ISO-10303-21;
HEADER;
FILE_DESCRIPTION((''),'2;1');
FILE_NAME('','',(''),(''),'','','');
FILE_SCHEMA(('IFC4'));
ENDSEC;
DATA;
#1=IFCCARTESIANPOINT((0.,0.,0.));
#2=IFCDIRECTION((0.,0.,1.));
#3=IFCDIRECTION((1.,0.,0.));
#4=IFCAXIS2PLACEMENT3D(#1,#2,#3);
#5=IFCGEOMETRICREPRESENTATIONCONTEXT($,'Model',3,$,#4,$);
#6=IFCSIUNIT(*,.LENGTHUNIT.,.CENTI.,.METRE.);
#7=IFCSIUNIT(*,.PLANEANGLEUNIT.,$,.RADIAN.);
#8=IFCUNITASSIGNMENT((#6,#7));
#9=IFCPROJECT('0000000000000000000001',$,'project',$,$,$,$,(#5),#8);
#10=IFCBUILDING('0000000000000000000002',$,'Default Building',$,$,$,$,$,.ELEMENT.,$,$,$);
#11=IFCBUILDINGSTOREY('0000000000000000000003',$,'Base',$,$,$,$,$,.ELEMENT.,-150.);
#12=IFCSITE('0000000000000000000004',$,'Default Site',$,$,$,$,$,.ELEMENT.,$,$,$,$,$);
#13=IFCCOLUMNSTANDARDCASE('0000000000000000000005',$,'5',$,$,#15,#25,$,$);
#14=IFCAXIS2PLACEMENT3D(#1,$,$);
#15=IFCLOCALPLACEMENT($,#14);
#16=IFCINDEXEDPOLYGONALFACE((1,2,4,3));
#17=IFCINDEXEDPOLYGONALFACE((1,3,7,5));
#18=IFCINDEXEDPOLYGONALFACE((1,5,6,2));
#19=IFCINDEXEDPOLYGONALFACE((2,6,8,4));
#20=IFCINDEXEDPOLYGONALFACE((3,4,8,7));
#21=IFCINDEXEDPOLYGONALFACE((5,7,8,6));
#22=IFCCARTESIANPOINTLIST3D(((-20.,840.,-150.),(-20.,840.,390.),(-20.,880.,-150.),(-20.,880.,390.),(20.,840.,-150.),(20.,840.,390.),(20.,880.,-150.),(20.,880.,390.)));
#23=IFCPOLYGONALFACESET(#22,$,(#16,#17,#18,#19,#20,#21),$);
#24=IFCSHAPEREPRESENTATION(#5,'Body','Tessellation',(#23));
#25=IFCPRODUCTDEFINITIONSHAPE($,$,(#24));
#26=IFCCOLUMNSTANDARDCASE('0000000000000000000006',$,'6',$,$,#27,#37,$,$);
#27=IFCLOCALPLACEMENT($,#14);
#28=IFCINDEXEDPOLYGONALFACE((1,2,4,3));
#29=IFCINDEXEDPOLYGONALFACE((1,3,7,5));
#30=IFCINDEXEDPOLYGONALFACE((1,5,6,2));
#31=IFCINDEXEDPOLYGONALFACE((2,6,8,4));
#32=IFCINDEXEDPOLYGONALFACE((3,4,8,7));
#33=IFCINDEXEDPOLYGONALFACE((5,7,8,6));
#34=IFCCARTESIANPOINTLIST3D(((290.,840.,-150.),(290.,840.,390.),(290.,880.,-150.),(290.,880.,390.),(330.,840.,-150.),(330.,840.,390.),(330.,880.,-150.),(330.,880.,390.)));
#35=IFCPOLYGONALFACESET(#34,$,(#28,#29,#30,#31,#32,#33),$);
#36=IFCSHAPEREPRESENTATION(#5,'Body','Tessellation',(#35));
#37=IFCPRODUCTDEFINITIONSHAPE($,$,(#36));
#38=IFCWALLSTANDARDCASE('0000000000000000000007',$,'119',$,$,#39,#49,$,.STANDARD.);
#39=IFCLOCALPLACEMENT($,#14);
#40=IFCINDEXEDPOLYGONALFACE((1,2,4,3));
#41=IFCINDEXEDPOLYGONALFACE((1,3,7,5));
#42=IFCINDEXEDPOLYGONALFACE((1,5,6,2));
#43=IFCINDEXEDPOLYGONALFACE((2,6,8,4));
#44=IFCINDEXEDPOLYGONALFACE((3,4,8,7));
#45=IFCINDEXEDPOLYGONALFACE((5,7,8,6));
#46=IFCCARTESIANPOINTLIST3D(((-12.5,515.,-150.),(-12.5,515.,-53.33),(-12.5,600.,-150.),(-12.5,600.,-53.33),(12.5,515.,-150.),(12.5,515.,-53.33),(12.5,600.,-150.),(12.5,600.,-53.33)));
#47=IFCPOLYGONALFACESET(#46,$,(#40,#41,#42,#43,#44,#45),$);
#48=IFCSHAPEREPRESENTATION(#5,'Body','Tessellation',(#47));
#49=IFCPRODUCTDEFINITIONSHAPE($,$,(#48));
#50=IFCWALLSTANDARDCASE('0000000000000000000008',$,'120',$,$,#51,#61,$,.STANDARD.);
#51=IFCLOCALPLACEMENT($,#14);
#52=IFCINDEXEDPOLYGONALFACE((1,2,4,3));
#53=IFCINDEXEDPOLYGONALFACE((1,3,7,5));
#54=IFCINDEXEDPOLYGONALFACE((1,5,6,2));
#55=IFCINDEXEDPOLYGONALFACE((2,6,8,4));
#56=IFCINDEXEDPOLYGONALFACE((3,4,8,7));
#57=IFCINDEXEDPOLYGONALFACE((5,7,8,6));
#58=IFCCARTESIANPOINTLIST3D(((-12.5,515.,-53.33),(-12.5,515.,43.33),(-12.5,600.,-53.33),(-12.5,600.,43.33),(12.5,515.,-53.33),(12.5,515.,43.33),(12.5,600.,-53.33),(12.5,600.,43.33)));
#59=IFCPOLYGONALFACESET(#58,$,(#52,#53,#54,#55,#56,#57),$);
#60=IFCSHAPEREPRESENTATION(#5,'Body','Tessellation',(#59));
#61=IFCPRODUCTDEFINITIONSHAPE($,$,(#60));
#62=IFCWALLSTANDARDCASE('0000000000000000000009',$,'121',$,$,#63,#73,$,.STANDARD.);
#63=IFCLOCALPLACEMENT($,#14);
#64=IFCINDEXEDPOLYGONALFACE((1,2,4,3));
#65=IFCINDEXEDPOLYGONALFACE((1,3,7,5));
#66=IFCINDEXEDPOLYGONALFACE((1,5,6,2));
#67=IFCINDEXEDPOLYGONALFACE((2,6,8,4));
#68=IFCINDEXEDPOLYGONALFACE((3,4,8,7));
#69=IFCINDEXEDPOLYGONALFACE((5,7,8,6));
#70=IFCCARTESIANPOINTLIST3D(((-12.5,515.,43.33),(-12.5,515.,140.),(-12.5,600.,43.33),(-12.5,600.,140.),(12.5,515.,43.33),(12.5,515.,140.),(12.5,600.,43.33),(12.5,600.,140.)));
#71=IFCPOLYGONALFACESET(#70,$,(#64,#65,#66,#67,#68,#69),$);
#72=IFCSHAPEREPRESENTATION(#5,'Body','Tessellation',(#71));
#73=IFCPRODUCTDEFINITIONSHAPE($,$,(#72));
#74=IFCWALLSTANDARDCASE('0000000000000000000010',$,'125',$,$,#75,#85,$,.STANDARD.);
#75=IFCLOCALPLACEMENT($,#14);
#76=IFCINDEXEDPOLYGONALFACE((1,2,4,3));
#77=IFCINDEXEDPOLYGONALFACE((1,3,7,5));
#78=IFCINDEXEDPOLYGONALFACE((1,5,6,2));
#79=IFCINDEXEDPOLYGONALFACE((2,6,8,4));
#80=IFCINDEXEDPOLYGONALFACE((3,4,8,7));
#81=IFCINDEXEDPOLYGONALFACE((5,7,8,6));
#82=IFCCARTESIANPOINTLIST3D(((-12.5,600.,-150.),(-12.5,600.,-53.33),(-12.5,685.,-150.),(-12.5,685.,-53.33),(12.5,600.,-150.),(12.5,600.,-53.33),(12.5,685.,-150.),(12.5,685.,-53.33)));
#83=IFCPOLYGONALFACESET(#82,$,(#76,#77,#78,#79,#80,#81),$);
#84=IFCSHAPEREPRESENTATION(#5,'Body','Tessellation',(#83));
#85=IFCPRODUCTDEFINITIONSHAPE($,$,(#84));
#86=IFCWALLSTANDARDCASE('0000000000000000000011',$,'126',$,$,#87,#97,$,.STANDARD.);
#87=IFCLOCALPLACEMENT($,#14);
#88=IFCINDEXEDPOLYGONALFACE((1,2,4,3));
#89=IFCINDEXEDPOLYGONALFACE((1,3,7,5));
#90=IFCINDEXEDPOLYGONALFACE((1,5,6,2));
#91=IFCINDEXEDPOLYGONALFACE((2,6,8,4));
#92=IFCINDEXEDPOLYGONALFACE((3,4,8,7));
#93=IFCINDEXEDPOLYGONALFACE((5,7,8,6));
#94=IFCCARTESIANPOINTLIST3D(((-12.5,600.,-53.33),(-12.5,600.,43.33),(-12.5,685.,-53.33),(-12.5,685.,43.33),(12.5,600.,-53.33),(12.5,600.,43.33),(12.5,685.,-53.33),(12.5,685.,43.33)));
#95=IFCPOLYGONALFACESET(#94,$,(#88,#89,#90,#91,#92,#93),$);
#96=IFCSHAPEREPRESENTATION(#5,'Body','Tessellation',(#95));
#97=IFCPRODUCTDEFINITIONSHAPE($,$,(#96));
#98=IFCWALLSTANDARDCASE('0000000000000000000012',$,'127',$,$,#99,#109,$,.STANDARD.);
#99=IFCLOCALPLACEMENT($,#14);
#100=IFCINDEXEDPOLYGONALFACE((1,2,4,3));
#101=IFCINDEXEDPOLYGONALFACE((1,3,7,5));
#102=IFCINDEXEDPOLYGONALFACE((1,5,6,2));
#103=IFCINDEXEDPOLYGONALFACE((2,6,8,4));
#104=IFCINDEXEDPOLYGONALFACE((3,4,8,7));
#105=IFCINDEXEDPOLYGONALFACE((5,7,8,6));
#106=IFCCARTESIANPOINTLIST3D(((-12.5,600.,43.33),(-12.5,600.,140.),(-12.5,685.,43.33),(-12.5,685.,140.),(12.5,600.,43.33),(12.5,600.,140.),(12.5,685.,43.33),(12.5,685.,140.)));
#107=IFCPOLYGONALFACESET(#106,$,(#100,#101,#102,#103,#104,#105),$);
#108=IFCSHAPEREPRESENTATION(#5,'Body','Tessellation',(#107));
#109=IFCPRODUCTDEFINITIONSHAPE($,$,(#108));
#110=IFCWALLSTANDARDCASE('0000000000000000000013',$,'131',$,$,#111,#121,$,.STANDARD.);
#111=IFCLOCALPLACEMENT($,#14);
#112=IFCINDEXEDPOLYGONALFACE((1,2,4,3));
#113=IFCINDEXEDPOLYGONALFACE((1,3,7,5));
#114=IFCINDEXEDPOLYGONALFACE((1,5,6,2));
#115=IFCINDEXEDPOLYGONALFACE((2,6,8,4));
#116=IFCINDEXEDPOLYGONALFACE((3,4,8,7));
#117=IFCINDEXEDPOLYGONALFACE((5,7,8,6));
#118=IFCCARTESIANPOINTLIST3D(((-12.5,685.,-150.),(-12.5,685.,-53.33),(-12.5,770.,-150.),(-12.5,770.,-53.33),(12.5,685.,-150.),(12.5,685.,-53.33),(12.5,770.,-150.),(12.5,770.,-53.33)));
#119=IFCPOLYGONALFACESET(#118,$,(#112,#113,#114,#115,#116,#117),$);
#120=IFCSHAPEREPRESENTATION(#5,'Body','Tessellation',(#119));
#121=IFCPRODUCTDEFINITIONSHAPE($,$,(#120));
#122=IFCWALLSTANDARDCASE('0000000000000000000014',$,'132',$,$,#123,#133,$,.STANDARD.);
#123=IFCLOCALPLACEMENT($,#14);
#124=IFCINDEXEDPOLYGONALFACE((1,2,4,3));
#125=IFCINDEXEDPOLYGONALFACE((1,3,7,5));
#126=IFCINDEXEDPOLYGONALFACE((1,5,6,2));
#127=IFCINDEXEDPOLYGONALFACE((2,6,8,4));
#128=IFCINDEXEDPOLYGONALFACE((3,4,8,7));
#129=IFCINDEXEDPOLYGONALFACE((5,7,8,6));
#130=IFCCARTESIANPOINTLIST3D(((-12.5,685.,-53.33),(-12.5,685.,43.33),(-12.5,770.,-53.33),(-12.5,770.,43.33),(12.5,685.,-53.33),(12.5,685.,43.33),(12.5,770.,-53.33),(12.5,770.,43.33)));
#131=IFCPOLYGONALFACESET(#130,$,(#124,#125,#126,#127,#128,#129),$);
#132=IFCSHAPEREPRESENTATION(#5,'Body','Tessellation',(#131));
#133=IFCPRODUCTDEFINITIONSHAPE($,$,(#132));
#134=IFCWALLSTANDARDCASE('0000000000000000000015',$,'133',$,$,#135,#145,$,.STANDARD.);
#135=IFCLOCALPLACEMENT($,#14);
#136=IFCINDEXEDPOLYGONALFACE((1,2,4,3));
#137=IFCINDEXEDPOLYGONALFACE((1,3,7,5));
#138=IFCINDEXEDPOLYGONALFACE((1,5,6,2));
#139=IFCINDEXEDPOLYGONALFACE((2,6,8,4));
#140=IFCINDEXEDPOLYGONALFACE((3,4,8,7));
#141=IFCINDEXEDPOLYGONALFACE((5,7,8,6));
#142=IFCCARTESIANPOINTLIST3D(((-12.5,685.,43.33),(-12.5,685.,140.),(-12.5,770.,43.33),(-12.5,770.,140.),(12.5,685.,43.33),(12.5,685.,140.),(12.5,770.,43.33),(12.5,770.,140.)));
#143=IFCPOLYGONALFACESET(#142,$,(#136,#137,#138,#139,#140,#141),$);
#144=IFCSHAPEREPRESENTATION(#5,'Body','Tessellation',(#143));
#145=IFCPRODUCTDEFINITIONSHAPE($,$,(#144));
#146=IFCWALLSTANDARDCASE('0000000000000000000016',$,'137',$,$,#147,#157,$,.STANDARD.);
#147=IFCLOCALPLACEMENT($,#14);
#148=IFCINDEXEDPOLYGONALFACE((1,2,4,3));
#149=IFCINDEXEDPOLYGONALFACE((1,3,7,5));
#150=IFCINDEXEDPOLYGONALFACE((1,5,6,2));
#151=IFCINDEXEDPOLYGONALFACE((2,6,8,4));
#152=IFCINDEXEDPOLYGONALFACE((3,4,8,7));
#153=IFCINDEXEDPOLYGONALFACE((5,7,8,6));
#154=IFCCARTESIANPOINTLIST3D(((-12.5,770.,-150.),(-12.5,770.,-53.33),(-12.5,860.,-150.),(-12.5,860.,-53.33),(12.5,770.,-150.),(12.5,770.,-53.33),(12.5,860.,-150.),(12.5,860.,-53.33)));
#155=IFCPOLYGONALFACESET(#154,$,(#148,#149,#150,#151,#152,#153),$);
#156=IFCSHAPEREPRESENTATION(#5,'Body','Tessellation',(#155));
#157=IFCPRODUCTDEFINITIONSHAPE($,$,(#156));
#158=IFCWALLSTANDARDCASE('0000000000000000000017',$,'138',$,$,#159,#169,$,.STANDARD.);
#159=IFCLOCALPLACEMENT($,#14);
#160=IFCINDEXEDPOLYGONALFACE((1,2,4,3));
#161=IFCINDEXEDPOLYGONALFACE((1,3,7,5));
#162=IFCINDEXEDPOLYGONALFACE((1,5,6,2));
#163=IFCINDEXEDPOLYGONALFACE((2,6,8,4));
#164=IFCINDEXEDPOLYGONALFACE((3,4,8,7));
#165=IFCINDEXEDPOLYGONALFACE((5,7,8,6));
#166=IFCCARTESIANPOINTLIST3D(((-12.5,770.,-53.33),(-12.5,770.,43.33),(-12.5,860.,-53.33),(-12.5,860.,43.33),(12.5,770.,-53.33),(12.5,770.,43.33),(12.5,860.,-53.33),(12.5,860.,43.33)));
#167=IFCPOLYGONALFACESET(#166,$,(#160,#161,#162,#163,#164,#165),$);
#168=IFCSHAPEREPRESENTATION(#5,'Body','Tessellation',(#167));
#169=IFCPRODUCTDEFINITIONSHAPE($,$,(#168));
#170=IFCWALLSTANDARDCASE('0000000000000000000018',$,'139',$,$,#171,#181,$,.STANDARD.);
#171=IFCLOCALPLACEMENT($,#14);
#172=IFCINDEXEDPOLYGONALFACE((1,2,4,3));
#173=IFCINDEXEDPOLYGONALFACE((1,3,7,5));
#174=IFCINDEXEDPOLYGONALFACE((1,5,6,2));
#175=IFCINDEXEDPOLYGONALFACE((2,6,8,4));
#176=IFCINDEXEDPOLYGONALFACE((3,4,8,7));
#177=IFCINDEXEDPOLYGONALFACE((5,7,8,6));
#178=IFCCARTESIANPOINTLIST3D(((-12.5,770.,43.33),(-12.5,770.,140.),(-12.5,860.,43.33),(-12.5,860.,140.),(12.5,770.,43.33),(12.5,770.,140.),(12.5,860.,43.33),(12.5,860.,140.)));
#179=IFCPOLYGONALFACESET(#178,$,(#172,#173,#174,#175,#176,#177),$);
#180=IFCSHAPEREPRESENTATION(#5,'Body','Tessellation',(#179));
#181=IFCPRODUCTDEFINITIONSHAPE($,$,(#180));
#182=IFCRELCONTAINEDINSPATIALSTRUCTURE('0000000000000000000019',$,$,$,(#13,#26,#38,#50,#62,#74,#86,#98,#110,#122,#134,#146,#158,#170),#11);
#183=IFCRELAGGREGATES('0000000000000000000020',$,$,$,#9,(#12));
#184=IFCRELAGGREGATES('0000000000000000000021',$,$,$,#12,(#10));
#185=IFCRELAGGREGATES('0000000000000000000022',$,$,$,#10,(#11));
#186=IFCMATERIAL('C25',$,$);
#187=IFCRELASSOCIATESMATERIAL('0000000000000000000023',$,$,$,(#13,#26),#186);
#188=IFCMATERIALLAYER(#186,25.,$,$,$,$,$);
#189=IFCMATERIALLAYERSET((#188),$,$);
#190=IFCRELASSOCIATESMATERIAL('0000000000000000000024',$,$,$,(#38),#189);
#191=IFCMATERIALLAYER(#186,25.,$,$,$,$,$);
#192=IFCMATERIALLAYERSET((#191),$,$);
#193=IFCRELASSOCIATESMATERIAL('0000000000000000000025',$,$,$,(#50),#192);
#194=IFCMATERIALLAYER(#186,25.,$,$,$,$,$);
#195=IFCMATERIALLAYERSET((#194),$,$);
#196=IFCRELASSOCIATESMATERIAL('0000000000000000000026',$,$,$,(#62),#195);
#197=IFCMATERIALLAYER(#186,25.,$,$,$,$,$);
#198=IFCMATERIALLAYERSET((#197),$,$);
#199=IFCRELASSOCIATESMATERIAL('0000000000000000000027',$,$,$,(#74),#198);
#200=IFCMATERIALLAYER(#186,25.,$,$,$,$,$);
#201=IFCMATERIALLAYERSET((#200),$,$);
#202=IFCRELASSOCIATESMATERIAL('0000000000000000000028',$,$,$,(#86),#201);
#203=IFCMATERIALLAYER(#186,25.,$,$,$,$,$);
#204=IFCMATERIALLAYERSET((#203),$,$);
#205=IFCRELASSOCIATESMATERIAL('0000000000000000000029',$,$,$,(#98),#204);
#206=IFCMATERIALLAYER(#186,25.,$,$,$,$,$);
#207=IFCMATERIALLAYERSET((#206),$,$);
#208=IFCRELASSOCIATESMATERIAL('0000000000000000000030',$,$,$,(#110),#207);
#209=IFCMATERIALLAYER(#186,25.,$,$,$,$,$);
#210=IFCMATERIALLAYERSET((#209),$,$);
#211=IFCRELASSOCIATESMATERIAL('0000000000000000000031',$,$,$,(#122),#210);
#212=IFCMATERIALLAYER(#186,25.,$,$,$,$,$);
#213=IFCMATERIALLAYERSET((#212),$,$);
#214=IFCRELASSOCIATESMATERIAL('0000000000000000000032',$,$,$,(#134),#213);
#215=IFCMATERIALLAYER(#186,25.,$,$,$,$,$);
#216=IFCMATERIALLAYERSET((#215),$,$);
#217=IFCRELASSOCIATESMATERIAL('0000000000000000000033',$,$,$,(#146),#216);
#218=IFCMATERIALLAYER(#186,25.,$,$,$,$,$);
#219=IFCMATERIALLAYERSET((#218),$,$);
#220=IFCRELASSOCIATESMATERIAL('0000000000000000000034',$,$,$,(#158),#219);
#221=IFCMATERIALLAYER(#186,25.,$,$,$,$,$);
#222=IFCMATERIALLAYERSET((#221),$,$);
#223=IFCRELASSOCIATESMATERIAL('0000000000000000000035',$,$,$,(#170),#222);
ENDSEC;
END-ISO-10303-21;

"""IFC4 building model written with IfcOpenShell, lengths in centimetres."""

from ifc_helpers import new_model, si_unit, frame, origin_with_axes, origin_2d_with_axis, place, context, project, spatial, rectangle, extrude, material, layer, layer_set, layer_usage, material_profile, profile_set, profile_usage, element, save


model = new_model("IFC4")

# Units and contexts
model_context = context("Model", 3, world=origin_with_axes())
ifc_project = project(units=[si_unit("LENGTHUNIT", "METRE", prefix="CENTI"), si_unit("PLANEANGLEUNIT", "RADIAN")], contexts=[model_context])

# Site, building, storey
site = spatial("IfcSite", under=ifc_project, Name="Default Site", CompositionType="ELEMENT")
building = spatial("IfcBuilding", under=site, Name="Default Building", CompositionType="ELEMENT")
storey = spatial("IfcBuildingStorey", under=building, Name="Base", CompositionType="ELEMENT", Elevation=-150.0)

# Columns
ifc_material = material(Name="C25")
ifc_material_profile_1 = material_profile(ifc_material, rectangle(XDim=40.0, YDim=40.0, at=origin_2d_with_axis()))
ifc_profile_set_1 = profile_set([ifc_material_profile_1])
ifc_profile_usage_1 = profile_usage(ifc_profile_set_1, cardinal=10)
column_1_placement = place(None, frame((0.0, 860.0, -150.0), z_axis=(0.0, 0.0, 1.0), x_axis=(0.0, -1.0, 0.0)))
element("IfcColumnStandardCase", 1, at=column_1_placement, inside=storey, material=ifc_profile_usage_1, Name="5", context=model_context, shape_type="SweptSolid", body=[
    extrude(rectangle(XDim=40.0, YDim=40.0, at=origin_2d_with_axis()), origin_with_axes(), (0.0, 0.0, 1.0), 540.0),
])
ifc_material_profile_2 = material_profile(ifc_material, rectangle(XDim=40.0, YDim=40.0, at=origin_2d_with_axis()))
ifc_profile_set_2 = profile_set([ifc_material_profile_2])
ifc_profile_usage_2 = profile_usage(ifc_profile_set_2, cardinal=10)
column_2_placement = place(None, frame((310.0, 860.0, -150.0), z_axis=(0.0, 0.0, 1.0), x_axis=(0.0, -1.0, 0.0)))
element("IfcColumnStandardCase", 2, at=column_2_placement, inside=storey, material=ifc_profile_usage_2, Name="6", context=model_context, shape_type="SweptSolid", body=[
    extrude(rectangle(XDim=40.0, YDim=40.0, at=origin_2d_with_axis()), origin_with_axes(), (0.0, 0.0, 1.0), 540.0),
])

# Walls
ifc_layer_1 = layer(ifc_material, 25.0)
ifc_layer_set_1 = layer_set([ifc_layer_1])
ifc_layer_usage_1 = layer_usage(ifc_layer_set_1, "AXIS2", "POSITIVE", -25.0)
wall_1_placement = place(None, frame((0.0, 557.5, -150.0), z_axis=(0.0, 0.0, 1.0), x_axis=(0.0, 1.0, 0.0)))
element("IfcWallStandardCase", 3, at=wall_1_placement, inside=storey, material=ifc_layer_usage_1, Name="119", PredefinedType="STANDARD", context=model_context, shape_type="SweptSolid", body=[
    extrude(rectangle(XDim=85.0, YDim=25.0, at=origin_2d_with_axis()), origin_with_axes(), (0.0, 0.0, 1.0), 96.67),
])
ifc_layer_2 = layer(ifc_material, 25.0)
ifc_layer_set_2 = layer_set([ifc_layer_2])
ifc_layer_usage_2 = layer_usage(ifc_layer_set_2, "AXIS2", "POSITIVE", -25.0)
wall_2_placement = place(None, frame((0.0, 557.5, -53.33), z_axis=(0.0, 0.0, 1.0), x_axis=(0.0, 1.0, 0.0)))
element("IfcWallStandardCase", 4, at=wall_2_placement, inside=storey, material=ifc_layer_usage_2, Name="120", PredefinedType="STANDARD", context=model_context, shape_type="SweptSolid", body=[
    extrude(rectangle(XDim=85.0, YDim=25.0, at=origin_2d_with_axis()), origin_with_axes(), (0.0, 0.0, 1.0), 96.67),
])
ifc_layer_3 = layer(ifc_material, 25.0)
ifc_layer_set_3 = layer_set([ifc_layer_3])
ifc_layer_usage_3 = layer_usage(ifc_layer_set_3, "AXIS2", "POSITIVE", -25.0)
wall_3_placement = place(None, frame((0.0, 557.5, 43.33), z_axis=(0.0, 0.0, 1.0), x_axis=(0.0, 1.0, 0.0)))
element("IfcWallStandardCase", 5, at=wall_3_placement, inside=storey, material=ifc_layer_usage_3, Name="121", PredefinedType="STANDARD", context=model_context, shape_type="SweptSolid", body=[
    extrude(rectangle(XDim=85.0, YDim=25.0, at=origin_2d_with_axis()), origin_with_axes(), (0.0, 0.0, 1.0), 96.67),
])
ifc_layer_4 = layer(ifc_material, 25.0)
ifc_layer_set_4 = layer_set([ifc_layer_4])
ifc_layer_usage_4 = layer_usage(ifc_layer_set_4, "AXIS2", "POSITIVE", -25.0)
wall_4_placement = place(None, frame((0.0, 642.5, -150.0), z_axis=(0.0, 0.0, 1.0), x_axis=(0.0, 1.0, 0.0)))
element("IfcWallStandardCase", 6, at=wall_4_placement, inside=storey, material=ifc_layer_usage_4, Name="125", PredefinedType="STANDARD", context=model_context, shape_type="SweptSolid", body=[
    extrude(rectangle(XDim=85.0, YDim=25.0, at=origin_2d_with_axis()), origin_with_axes(), (0.0, 0.0, 1.0), 96.67),
])
ifc_layer_5 = layer(ifc_material, 25.0)
ifc_layer_set_5 = layer_set([ifc_layer_5])
ifc_layer_usage_5 = layer_usage(ifc_layer_set_5, "AXIS2", "POSITIVE", -25.0)
wall_5_placement = place(None, frame((0.0, 642.5, -53.33), z_axis=(0.0, 0.0, 1.0), x_axis=(0.0, 1.0, 0.0)))
element("IfcWallStandardCase", 7, at=wall_5_placement, inside=storey, material=ifc_layer_usage_5, Name="126", PredefinedType="STANDARD", context=model_context, shape_type="SweptSolid", body=[
    extrude(rectangle(XDim=85.0, YDim=25.0, at=origin_2d_with_axis()), origin_with_axes(), (0.0, 0.0, 1.0), 96.67),
])
ifc_layer_6 = layer(ifc_material, 25.0)
ifc_layer_set_6 = layer_set([ifc_layer_6])
ifc_layer_usage_6 = layer_usage(ifc_layer_set_6, "AXIS2", "POSITIVE", -25.0)
wall_6_placement = place(None, frame((0.0, 642.5, 43.33), z_axis=(0.0, 0.0, 1.0), x_axis=(0.0, 1.0, 0.0)))
element("IfcWallStandardCase", 8, at=wall_6_placement, inside=storey, material=ifc_layer_usage_6, Name="127", PredefinedType="STANDARD", context=model_context, shape_type="SweptSolid", body=[
    extrude(rectangle(XDim=85.0, YDim=25.0, at=origin_2d_with_axis()), origin_with_axes(), (0.0, 0.0, 1.0), 96.67),
])
ifc_layer_7 = layer(ifc_material, 25.0)
ifc_layer_set_7 = layer_set([ifc_layer_7])
ifc_layer_usage_7 = layer_usage(ifc_layer_set_7, "AXIS2", "POSITIVE", -25.0)
wall_7_placement = place(None, frame((0.0, 727.5, -150.0), z_axis=(0.0, 0.0, 1.0), x_axis=(0.0, 1.0, 0.0)))
element("IfcWallStandardCase", 9, at=wall_7_placement, inside=storey, material=ifc_layer_usage_7, Name="131", PredefinedType="STANDARD", context=model_context, shape_type="SweptSolid", body=[
    extrude(rectangle(XDim=85.0, YDim=25.0, at=origin_2d_with_axis()), origin_with_axes(), (0.0, 0.0, 1.0), 96.67),
])
ifc_layer_8 = layer(ifc_material, 25.0)
ifc_layer_set_8 = layer_set([ifc_layer_8])
ifc_layer_usage_8 = layer_usage(ifc_layer_set_8, "AXIS2", "POSITIVE", -25.0)
wall_8_placement = place(None, frame((0.0, 727.5, -53.33), z_axis=(0.0, 0.0, 1.0), x_axis=(0.0, 1.0, 0.0)))
element("IfcWallStandardCase", 10, at=wall_8_placement, inside=storey, material=ifc_layer_usage_8, Name="132", PredefinedType="STANDARD", context=model_context, shape_type="SweptSolid", body=[
    extrude(rectangle(XDim=85.0, YDim=25.0, at=origin_2d_with_axis()), origin_with_axes(), (0.0, 0.0, 1.0), 96.67),
])
ifc_layer_9 = layer(ifc_material, 25.0)
ifc_layer_set_9 = layer_set([ifc_layer_9])
ifc_layer_usage_9 = layer_usage(ifc_layer_set_9, "AXIS2", "POSITIVE", -25.0)
wall_9_placement = place(None, frame((0.0, 727.5, 43.33), z_axis=(0.0, 0.0, 1.0), x_axis=(0.0, 1.0, 0.0)))
element("IfcWallStandardCase", 11, at=wall_9_placement, inside=storey, material=ifc_layer_usage_9, Name="133", PredefinedType="STANDARD", context=model_context, shape_type="SweptSolid", body=[
    extrude(rectangle(XDim=85.0, YDim=25.0, at=origin_2d_with_axis()), origin_with_axes(), (0.0, 0.0, 1.0), 96.67),
])
ifc_layer_10 = layer(ifc_material, 25.0)
ifc_layer_set_10 = layer_set([ifc_layer_10])
ifc_layer_usage_10 = layer_usage(ifc_layer_set_10, "AXIS2", "POSITIVE", -25.0)
wall_10_placement = place(None, frame((0.0, 815.0, -150.0), z_axis=(0.0, 0.0, 1.0), x_axis=(0.0, 1.0, 0.0)))
element("IfcWallStandardCase", 12, at=wall_10_placement, inside=storey, material=ifc_layer_usage_10, Name="137", PredefinedType="STANDARD", context=model_context, shape_type="SweptSolid", body=[
    extrude(rectangle(XDim=90.0, YDim=25.0, at=origin_2d_with_axis()), origin_with_axes(), (0.0, 0.0, 1.0), 96.67),
])
ifc_layer_11 = layer(ifc_material, 25.0)
ifc_layer_set_11 = layer_set([ifc_layer_11])
ifc_layer_usage_11 = layer_usage(ifc_layer_set_11, "AXIS2", "POSITIVE", -25.0)
wall_11_placement = place(None, frame((0.0, 815.0, -53.33), z_axis=(0.0, 0.0, 1.0), x_axis=(0.0, 1.0, 0.0)))
element("IfcWallStandardCase", 13, at=wall_11_placement, inside=storey, material=ifc_layer_usage_11, Name="138", PredefinedType="STANDARD", context=model_context, shape_type="SweptSolid", body=[
    extrude(rectangle(XDim=90.0, YDim=25.0, at=origin_2d_with_axis()), origin_with_axes(), (0.0, 0.0, 1.0), 96.67),
])
ifc_layer_12 = layer(ifc_material, 25.0)
ifc_layer_set_12 = layer_set([ifc_layer_12])
ifc_layer_usage_12 = layer_usage(ifc_layer_set_12, "AXIS2", "POSITIVE", -25.0)
wall_12_placement = place(None, frame((0.0, 815.0, 43.33), z_axis=(0.0, 0.0, 1.0), x_axis=(0.0, 1.0, 0.0)))
element("IfcWallStandardCase", 14, at=wall_12_placement, inside=storey, material=ifc_layer_usage_12, Name="139", PredefinedType="STANDARD", context=model_context, shape_type="SweptSolid", body=[
    extrude(rectangle(XDim=90.0, YDim=25.0, at=origin_2d_with_axis()), origin_with_axes(), (0.0, 0.0, 1.0), 96.67),
])

save(model, "model.ifc")
